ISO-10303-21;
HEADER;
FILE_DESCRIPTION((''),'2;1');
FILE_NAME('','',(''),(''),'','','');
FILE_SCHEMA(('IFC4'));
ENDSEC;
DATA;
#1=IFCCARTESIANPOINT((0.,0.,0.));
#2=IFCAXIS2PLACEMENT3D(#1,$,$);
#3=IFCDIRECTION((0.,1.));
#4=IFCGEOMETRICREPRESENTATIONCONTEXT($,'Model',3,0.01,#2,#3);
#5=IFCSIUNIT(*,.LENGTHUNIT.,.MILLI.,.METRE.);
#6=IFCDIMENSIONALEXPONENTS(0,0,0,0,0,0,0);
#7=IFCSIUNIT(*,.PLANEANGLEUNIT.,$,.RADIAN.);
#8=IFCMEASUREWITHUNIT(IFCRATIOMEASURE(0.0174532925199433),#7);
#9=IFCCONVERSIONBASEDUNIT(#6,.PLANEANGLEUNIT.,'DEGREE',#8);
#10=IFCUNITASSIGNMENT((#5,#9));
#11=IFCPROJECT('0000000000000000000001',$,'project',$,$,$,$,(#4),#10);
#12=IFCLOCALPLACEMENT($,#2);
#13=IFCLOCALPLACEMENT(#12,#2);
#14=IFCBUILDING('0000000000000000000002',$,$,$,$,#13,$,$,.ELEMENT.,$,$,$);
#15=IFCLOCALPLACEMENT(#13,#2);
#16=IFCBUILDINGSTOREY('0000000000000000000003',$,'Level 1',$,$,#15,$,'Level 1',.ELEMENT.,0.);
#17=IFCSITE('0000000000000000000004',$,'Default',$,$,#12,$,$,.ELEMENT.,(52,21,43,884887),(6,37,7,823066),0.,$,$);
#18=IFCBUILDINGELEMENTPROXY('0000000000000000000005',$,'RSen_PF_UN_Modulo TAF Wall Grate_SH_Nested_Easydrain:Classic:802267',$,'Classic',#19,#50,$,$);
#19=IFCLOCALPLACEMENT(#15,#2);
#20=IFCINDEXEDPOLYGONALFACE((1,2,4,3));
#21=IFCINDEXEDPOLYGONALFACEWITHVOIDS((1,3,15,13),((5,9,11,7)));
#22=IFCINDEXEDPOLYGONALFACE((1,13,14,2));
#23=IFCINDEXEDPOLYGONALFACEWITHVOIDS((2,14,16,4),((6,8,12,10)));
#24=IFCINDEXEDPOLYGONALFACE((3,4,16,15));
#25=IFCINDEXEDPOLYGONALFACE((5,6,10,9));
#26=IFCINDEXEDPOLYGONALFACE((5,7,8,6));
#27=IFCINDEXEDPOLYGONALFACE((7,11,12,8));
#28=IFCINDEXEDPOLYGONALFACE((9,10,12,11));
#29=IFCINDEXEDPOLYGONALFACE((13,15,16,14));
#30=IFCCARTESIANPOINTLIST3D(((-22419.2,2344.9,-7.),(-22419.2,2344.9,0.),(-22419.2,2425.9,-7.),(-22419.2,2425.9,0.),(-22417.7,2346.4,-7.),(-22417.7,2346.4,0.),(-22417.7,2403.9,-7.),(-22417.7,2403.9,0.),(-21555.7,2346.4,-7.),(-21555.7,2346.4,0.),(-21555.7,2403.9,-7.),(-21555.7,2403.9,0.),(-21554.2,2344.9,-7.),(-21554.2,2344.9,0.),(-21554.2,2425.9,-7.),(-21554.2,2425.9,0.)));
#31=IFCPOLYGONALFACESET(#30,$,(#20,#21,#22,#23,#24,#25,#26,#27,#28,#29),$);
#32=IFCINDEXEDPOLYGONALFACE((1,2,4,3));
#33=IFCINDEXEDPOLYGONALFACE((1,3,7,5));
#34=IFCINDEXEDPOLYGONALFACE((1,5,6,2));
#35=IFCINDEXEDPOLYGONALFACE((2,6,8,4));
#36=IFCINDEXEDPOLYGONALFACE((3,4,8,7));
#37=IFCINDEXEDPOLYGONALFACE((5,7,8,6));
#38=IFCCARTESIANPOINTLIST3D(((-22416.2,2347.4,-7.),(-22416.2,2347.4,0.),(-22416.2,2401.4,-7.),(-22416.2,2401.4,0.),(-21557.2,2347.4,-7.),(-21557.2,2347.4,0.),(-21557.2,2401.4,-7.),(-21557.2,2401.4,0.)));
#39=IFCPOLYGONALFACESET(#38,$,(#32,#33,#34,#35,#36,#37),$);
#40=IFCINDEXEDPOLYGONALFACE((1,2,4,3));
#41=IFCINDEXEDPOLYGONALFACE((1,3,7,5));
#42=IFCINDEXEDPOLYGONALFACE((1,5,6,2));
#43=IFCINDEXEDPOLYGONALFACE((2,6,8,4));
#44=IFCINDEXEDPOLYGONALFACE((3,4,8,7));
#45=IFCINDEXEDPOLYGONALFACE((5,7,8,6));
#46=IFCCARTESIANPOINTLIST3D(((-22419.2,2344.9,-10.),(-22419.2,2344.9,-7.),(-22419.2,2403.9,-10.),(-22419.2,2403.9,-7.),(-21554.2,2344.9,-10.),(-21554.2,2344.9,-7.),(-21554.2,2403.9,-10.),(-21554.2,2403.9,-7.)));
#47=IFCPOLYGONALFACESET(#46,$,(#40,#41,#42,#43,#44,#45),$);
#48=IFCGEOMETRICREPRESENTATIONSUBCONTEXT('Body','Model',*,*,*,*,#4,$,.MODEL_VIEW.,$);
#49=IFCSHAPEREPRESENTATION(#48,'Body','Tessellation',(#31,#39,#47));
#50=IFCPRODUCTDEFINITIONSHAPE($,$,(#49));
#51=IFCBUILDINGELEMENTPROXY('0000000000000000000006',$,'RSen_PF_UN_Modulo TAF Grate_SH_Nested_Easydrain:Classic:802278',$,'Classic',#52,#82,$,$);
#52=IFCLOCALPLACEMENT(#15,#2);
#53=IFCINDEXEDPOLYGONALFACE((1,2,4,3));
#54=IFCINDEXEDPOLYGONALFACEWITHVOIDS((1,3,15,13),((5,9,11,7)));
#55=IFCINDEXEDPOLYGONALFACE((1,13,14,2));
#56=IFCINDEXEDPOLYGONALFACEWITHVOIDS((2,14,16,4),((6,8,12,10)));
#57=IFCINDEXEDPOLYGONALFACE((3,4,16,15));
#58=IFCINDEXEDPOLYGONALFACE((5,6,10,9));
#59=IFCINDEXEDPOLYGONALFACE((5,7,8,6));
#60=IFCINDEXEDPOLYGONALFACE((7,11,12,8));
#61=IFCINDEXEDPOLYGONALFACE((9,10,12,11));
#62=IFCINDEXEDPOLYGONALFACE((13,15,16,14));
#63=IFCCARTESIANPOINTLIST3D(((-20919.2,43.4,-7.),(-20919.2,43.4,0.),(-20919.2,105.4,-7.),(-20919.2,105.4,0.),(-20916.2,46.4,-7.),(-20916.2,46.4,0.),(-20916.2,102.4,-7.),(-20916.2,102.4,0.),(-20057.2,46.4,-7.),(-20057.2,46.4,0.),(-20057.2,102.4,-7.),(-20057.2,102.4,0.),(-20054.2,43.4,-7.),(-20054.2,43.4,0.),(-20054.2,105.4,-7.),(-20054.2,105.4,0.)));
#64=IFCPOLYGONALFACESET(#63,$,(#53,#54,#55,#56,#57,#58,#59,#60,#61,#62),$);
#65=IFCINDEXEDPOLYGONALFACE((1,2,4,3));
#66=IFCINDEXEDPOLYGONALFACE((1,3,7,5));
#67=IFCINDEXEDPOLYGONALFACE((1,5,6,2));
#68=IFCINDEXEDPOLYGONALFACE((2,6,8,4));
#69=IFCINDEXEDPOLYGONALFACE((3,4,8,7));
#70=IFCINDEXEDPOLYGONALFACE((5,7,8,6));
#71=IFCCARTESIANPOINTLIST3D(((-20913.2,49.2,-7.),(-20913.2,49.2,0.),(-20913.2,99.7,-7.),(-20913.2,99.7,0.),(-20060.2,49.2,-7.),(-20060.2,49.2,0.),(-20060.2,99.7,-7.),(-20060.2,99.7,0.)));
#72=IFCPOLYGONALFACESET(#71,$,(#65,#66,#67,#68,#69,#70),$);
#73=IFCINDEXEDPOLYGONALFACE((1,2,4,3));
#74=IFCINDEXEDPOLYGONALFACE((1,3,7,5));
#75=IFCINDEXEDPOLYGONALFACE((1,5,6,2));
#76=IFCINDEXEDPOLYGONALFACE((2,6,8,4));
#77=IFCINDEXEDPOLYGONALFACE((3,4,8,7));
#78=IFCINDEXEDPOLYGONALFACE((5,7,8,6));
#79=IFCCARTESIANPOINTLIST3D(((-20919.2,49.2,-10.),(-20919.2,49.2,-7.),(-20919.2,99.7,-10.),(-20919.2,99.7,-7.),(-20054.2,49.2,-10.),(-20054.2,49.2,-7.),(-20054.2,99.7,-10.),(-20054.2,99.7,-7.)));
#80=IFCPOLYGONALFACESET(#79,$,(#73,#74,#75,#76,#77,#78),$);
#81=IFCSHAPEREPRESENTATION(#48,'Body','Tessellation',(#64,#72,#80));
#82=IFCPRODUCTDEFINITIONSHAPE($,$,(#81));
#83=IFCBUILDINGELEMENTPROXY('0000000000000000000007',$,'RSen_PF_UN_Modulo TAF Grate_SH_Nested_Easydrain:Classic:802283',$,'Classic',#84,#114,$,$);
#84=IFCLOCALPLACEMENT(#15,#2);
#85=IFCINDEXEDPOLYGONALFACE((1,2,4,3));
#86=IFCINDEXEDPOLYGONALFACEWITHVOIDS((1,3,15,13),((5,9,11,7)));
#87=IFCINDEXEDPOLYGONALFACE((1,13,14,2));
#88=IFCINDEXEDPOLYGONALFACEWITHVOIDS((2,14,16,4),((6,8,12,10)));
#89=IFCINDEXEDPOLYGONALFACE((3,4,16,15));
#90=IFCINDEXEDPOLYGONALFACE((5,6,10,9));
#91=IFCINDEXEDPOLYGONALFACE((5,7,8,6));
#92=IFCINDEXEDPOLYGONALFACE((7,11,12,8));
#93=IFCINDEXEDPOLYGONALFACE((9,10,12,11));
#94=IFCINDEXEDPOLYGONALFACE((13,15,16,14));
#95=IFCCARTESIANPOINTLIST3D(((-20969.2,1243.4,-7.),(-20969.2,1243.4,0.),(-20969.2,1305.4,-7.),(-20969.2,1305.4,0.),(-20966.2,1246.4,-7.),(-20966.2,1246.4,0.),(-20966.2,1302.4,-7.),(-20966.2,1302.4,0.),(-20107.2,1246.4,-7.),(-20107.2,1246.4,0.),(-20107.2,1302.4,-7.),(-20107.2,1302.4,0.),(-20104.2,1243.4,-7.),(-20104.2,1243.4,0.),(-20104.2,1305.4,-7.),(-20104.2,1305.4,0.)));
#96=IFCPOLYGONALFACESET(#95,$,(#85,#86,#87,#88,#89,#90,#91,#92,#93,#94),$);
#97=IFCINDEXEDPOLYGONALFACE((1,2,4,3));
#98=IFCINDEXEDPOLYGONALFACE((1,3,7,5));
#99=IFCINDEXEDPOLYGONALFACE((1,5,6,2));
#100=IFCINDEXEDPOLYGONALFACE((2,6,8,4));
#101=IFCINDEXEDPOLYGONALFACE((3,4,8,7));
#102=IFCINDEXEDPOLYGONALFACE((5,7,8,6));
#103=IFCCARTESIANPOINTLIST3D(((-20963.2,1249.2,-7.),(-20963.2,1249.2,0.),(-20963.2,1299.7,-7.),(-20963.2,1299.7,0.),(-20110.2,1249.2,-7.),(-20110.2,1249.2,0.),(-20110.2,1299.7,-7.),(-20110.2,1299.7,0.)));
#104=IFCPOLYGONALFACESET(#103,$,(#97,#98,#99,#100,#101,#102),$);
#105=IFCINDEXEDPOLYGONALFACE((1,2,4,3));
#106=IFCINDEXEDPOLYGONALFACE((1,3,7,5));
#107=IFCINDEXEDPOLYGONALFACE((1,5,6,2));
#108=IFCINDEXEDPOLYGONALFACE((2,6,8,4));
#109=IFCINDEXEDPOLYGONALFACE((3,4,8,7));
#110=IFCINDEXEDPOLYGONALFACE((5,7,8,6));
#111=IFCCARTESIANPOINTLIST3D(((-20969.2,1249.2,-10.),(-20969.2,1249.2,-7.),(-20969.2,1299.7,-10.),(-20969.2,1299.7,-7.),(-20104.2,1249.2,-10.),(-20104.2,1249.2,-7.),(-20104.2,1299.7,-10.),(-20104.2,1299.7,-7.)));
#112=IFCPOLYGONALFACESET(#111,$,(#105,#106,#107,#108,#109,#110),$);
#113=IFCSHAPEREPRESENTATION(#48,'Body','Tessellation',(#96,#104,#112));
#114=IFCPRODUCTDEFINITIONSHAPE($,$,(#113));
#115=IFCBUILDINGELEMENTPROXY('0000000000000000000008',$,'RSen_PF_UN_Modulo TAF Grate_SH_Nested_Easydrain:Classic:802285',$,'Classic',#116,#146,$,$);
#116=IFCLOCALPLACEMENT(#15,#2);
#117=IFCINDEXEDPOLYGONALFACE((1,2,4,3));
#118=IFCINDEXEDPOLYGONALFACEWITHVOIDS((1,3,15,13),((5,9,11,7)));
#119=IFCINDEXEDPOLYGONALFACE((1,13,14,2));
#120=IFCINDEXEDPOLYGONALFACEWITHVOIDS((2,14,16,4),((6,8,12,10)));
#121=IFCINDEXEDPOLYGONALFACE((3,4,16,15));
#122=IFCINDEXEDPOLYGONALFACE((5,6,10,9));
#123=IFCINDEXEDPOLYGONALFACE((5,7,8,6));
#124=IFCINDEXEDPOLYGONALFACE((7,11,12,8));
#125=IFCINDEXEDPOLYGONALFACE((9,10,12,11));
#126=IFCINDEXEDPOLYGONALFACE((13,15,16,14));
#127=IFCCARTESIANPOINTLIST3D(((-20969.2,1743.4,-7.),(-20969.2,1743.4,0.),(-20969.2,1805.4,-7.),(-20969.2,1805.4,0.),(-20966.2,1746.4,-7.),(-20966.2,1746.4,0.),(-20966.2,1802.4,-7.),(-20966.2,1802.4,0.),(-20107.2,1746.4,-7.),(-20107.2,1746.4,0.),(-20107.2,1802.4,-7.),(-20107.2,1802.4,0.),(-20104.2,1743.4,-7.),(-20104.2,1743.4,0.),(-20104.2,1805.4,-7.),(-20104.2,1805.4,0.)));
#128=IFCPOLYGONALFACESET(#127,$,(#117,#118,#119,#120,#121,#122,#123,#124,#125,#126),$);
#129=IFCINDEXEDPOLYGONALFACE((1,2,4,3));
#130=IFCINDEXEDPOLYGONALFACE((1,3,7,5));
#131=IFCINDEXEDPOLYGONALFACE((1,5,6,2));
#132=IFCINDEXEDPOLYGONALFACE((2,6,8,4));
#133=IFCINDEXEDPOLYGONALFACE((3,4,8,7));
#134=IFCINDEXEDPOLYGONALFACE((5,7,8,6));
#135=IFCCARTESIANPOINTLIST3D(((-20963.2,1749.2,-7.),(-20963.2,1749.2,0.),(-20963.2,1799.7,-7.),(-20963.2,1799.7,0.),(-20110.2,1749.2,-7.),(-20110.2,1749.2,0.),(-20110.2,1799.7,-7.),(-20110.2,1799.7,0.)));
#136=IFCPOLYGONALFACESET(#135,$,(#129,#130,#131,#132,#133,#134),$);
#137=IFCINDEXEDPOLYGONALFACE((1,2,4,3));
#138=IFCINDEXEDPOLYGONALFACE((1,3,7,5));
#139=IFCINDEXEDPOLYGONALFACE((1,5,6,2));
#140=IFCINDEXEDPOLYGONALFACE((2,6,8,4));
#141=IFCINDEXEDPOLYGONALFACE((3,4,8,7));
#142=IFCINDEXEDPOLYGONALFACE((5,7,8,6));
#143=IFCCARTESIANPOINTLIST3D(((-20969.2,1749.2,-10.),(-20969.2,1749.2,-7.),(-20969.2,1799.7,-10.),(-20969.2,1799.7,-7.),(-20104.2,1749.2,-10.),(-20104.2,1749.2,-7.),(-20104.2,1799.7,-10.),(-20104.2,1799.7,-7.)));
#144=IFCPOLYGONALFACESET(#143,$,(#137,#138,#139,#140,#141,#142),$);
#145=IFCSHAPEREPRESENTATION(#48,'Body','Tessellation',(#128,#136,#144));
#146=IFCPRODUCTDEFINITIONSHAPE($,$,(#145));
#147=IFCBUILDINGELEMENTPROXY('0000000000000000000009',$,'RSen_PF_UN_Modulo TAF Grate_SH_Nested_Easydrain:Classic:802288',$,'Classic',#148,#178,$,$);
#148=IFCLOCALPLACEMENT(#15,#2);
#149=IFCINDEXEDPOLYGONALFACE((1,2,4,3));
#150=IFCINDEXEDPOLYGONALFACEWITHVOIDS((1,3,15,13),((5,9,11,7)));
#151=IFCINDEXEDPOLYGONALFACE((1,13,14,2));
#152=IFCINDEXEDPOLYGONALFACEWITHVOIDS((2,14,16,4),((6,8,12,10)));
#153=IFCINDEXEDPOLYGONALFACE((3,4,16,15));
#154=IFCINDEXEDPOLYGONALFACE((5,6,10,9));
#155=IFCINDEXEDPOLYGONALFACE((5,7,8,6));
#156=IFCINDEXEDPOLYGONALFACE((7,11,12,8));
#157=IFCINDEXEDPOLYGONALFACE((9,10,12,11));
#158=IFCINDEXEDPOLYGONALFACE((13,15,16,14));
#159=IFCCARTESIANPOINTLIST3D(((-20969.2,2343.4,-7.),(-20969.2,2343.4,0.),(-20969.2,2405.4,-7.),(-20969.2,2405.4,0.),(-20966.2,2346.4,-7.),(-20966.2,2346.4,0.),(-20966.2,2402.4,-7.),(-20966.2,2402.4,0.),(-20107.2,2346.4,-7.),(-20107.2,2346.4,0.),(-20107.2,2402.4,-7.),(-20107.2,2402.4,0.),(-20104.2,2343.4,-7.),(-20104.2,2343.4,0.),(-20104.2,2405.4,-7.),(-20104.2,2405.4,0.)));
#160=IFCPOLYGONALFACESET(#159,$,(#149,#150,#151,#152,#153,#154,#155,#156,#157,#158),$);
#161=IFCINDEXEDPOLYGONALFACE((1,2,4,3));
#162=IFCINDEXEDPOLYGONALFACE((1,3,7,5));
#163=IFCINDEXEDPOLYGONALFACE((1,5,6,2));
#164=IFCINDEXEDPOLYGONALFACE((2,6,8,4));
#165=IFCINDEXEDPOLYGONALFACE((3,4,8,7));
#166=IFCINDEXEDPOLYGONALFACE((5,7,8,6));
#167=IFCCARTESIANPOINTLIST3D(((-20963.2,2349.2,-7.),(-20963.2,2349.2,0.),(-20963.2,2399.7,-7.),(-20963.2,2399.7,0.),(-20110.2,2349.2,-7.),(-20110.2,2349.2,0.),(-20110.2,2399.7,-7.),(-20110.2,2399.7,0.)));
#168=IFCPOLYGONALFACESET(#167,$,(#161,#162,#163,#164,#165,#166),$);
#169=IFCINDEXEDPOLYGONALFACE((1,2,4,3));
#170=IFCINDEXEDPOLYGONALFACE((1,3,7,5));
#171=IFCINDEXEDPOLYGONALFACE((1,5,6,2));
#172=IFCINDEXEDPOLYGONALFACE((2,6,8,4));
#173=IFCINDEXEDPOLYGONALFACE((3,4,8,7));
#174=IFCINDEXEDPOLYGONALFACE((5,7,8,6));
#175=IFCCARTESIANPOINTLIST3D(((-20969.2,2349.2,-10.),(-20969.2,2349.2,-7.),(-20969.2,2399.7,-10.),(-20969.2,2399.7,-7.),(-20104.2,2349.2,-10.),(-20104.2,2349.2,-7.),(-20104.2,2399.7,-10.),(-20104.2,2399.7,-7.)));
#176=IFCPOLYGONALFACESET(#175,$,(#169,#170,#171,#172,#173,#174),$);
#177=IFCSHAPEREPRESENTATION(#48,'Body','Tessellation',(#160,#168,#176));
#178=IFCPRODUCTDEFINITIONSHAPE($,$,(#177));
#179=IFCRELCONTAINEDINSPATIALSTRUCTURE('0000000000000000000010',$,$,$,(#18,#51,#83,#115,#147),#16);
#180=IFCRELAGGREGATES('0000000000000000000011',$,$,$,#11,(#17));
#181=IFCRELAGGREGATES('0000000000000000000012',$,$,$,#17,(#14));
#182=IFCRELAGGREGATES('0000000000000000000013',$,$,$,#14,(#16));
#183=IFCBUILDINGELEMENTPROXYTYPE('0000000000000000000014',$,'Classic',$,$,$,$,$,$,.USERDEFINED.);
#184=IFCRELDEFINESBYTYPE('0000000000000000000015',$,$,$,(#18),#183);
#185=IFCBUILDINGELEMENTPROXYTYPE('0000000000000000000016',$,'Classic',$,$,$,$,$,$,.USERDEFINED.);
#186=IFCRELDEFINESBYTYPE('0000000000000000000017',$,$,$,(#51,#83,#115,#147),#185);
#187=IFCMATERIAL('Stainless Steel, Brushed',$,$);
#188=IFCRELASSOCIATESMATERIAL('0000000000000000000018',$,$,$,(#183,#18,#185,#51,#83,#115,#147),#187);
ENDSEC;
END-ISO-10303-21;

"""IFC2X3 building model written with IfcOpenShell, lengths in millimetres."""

from ifc_helpers import new_model, entity, si_unit, converted_unit, direction, frame, frame_2d, origin, origin_2d_with_axis, place, context, subcontext, project, spatial, polyline, rectangle, outline, extrude, source, transform, mapped, material, type_object, type_shapes, element, save


model = new_model("IFC2X3")

# Units and contexts
model_context = context("Model", 3, precision=0.01, world=origin(), true_north=direction((0.0, 1.0)))
body_context = subcontext(model_context, "Body", "Model", "MODEL_VIEW")
ifc_project = project(units=[si_unit("LENGTHUNIT", "METRE", prefix="MILLI"), converted_unit("PLANEANGLEUNIT", "DEGREE", entity("IfcRatioMeasure", 0.0174532925199433), si_unit("PLANEANGLEUNIT", "RADIAN"), dimensions=[0, 0, 0, 0, 0, 0, 0])], contexts=[model_context])

# Site, building, storey
site_placement = place(None, origin())
site = spatial("IfcSite", under=ifc_project, at=site_placement, Name="Default", CompositionType="ELEMENT", RefLatitude=(52, 21, 43, 884887), RefLongitude=(6, 37, 7, 823066), RefElevation=0.0)
building_placement = place(site_placement, origin())
building = spatial("IfcBuilding", under=site, at=building_placement, CompositionType="ELEMENT")
storey_placement = place(building_placement, origin())
storey = spatial("IfcBuildingStorey", under=building, at=storey_placement, Name="Level 1", LongName="Level 1", CompositionType="ELEMENT", Elevation=0.0)

# Shared definitions
ifc_material_1 = material(Name="Stainless Steel, Brushed")

# Building element proxies
building_element_proxy_type_1 = type_object("IfcBuildingElementProxyType", Name="Classic", PredefinedType="USERDEFINED", material=ifc_material_1)
shared_shape_1 = source(origin(), body_context, "Body", "SweptSolid", [
    extrude(outline(polyline([(-432.5, -40.5), (432.5, -40.5), (432.5, 40.5), (-432.5, 40.5), (-432.5, -40.5)]), holes=[polyline([(-431.0, -18.5), (-431.0, 39.0), (431.0, 39.0), (431.0, -18.5), (-431.0, -18.5)])]), frame((0.0, 11.0, 0.0), z_axis=(0.0, 0.0, 1.0), x_axis=(-1.0, 0.0, 0.0)), (0.0, 0.0, 1.0), 7.0),
    extrude(rectangle(XDim=859.0, YDim=54.0, at=origin_2d_with_axis()), frame((0.0, 0.0, 0.0), z_axis=(0.0, 0.0, 1.0), x_axis=(-1.0, 0.0, 0.0)), (0.0, 0.0, 1.0), 7.0),
    extrude(rectangle(XDim=865.0, YDim=59.0, at=origin_2d_with_axis()), frame((0.0, 0.0, -3.0), z_axis=(0.0, 0.0, 1.0), x_axis=(-1.0, 0.0, 0.0)), (0.0, 0.0, 1.0), 3.0),
])
type_shapes(building_element_proxy_type_1, [shared_shape_1])
for number, where, name in (
    (1, (-21986.7, 2374.4, -7.0), "RSen_PF_UN_Modulo TAF Wall Grate_SH_Nested_Easydrain:Classic:802267"),
):
    element("IfcBuildingElementProxy", number, at=place(storey_placement, frame(where)), inside=storey, type_object=building_element_proxy_type_1, material=ifc_material_1, Name=name, ObjectType="Classic", context=body_context, shape_type="MappedRepresentation", body=[
        mapped(shared_shape_1, transform((0.0, 0.0, 0.0), scale=1.0)),
    ])
building_element_proxy_type_2 = type_object("IfcBuildingElementProxyType", Name="Classic", PredefinedType="USERDEFINED", material=ifc_material_1)
shared_shape_2 = source(origin(), body_context, "Body", "SweptSolid", [
    extrude(outline(polyline([(-432.5, -31.0), (432.5, -31.0), (432.5, 31.0), (-432.5, 31.0), (-432.5, -31.0)]), holes=[polyline([(-429.5, -28.0), (-429.5, 28.0), (429.5, 28.0), (429.5, -28.0), (-429.5, -28.0)])]), frame((0.0, 0.0, 0.0), z_axis=(0.0, 0.0, 1.0), x_axis=(-1.0, 0.0, 0.0)), (0.0, 0.0, 1.0), 7.0),
    extrude(rectangle(XDim=853.0, YDim=50.5, at=frame_2d((0.0, 0.0), x_axis=(1.0, 0.0))), frame((0.0, 0.0, 0.0), z_axis=(0.0, 0.0, 1.0), x_axis=(-1.0, 0.0, 0.0)), (0.0, 0.0, 1.0), 7.0),
    extrude(rectangle(XDim=865.0, YDim=50.5, at=origin_2d_with_axis()), frame((0.0, 0.0, -3.0), z_axis=(0.0, 0.0, 1.0), x_axis=(-1.0, 0.0, 0.0)), (0.0, 0.0, 1.0), 3.0),
])
type_shapes(building_element_proxy_type_2, [shared_shape_2])
for number, where, name in (
    (2, (-20486.7, 74.4, -7.0), "RSen_PF_UN_Modulo TAF Grate_SH_Nested_Easydrain:Classic:802278"),
    (3, (-20536.7, 1274.4, -7.0), "RSen_PF_UN_Modulo TAF Grate_SH_Nested_Easydrain:Classic:802283"),
    (4, (-20536.7, 1774.4, -7.0), "RSen_PF_UN_Modulo TAF Grate_SH_Nested_Easydrain:Classic:802285"),
    (5, (-20536.7, 2374.4, -7.0), "RSen_PF_UN_Modulo TAF Grate_SH_Nested_Easydrain:Classic:802288"),
):
    element("IfcBuildingElementProxy", number, at=place(storey_placement, frame(where)), inside=storey, type_object=building_element_proxy_type_2, material=ifc_material_1, Name=name, ObjectType="Classic", context=body_context, shape_type="MappedRepresentation", body=[
        mapped(shared_shape_2, transform((0.0, 0.0, 0.0), scale=1.0)),
    ])

save(model, "model.ifc")
